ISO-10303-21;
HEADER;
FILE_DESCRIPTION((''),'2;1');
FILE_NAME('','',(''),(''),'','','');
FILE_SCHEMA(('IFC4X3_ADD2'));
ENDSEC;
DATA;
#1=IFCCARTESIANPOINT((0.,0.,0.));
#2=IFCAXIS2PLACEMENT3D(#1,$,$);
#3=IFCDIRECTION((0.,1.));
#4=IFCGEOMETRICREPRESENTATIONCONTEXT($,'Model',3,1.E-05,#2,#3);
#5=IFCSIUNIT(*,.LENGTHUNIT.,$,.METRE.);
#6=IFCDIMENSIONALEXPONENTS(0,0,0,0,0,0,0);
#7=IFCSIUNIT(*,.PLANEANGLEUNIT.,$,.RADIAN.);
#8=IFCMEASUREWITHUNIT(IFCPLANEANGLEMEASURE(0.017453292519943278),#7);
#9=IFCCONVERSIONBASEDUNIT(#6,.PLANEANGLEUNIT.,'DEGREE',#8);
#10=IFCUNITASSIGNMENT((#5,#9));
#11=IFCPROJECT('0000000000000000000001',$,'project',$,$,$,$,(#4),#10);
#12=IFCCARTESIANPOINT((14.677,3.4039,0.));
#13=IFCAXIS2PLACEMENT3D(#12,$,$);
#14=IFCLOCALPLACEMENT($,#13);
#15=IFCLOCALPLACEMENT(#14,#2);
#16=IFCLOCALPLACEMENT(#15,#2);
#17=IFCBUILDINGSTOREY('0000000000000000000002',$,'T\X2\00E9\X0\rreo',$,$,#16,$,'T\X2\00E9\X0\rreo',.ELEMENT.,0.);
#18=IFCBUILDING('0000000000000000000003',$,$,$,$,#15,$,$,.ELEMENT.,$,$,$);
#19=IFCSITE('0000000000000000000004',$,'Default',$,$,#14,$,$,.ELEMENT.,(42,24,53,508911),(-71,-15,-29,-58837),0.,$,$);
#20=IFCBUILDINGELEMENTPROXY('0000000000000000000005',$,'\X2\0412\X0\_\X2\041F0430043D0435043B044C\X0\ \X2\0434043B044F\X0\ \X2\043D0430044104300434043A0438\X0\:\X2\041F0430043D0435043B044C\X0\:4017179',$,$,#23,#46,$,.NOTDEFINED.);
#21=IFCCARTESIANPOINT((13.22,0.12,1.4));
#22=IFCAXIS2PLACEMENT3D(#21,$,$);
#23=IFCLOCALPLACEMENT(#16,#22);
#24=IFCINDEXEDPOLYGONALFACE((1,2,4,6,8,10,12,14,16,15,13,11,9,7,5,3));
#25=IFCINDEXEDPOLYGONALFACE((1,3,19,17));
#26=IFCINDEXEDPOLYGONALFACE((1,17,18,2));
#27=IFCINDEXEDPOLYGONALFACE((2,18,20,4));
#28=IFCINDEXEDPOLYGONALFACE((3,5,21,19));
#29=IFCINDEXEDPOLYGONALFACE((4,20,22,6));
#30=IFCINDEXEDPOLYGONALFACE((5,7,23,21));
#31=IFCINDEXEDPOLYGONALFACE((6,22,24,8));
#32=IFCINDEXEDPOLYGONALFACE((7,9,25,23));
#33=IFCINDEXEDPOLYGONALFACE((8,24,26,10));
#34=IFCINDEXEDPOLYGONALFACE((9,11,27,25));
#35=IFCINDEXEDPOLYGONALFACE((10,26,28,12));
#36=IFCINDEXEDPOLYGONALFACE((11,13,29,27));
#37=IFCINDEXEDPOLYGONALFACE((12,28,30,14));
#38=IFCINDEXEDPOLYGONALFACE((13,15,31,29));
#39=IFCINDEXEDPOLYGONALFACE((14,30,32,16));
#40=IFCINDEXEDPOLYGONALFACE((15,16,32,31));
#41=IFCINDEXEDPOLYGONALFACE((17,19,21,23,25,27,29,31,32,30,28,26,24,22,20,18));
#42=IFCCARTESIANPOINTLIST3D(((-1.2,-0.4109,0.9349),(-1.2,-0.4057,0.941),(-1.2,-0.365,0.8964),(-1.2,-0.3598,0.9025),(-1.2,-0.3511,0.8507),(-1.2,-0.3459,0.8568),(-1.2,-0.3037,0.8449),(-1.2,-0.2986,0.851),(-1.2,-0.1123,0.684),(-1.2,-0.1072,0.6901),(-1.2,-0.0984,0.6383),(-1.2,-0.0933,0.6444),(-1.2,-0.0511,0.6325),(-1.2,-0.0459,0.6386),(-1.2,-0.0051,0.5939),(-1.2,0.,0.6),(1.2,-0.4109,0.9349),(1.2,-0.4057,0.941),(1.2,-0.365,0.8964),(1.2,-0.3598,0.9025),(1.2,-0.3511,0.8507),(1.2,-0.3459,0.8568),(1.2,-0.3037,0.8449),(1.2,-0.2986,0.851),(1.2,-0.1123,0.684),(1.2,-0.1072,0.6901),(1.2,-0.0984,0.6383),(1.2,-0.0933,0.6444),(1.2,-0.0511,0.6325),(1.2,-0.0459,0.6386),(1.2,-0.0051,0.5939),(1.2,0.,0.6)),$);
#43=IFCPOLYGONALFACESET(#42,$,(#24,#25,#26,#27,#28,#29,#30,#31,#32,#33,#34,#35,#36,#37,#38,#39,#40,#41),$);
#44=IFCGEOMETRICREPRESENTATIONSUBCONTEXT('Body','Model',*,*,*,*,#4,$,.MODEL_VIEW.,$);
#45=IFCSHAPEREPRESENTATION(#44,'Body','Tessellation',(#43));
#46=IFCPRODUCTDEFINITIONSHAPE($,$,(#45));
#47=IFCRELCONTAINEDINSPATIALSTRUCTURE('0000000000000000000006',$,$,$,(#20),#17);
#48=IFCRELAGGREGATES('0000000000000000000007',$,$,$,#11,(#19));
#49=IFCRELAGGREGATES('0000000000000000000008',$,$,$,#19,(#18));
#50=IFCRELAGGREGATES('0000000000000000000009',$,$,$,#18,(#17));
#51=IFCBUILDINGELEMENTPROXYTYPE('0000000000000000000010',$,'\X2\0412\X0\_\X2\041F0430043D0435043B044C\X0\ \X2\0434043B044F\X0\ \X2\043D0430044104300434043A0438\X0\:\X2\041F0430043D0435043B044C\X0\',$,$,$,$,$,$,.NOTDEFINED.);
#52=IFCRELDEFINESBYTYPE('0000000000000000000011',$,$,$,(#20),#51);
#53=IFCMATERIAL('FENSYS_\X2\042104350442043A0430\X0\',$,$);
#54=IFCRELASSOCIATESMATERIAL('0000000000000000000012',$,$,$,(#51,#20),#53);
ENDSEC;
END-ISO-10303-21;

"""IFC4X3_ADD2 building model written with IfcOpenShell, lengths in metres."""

from ifc_helpers import new_model, entity, si_unit, converted_unit, direction, frame, origin, place, context, subcontext, project, spatial, polyline, outline, extrude, source, transform, mapped, material, type_object, type_shapes, element, save


model = new_model("IFC4X3_ADD2")

# Units and contexts
model_context = context("Model", 3, precision=1e-05, world=origin(), true_north=direction((0.0, 1.0)))
body_context = subcontext(model_context, "Body", "Model", "MODEL_VIEW")
ifc_project = project(units=[si_unit("LENGTHUNIT", "METRE"), converted_unit("PLANEANGLEUNIT", "DEGREE", entity("IfcPlaneAngleMeasure", 0.017453292519943278), si_unit("PLANEANGLEUNIT", "RADIAN"), dimensions=[0, 0, 0, 0, 0, 0, 0])], contexts=[model_context])

# Site, building, storey
site_placement = place(None, frame((14.677, 3.4039, 0.0)))
site = spatial("IfcSite", under=ifc_project, at=site_placement, Name="Default", CompositionType="ELEMENT", RefLatitude=(42, 24, 53, 508911), RefLongitude=(-71, -15, -29, -58837), RefElevation=0.0)
building_placement = place(site_placement, origin())
building = spatial("IfcBuilding", under=site, at=building_placement, CompositionType="ELEMENT")
storey_placement = place(building_placement, origin())
storey = spatial("IfcBuildingStorey", under=building, at=storey_placement, Name="Térreo", LongName="Térreo", CompositionType="ELEMENT", Elevation=0.0)

# Building element proxy
ifc_material_1 = material(Name="FENSYS_Сетка")
building_element_proxy_type_1 = type_object("IfcBuildingElementProxyType", Name="В_Панель для насадки:Панель", PredefinedType="NOTDEFINED", material=ifc_material_1)
shared_shape_1 = source(origin(), body_context, "Body", "SweptSolid", [
    extrude(outline(polyline([(0.205, -0.0105), (0.265, -0.0105), (0.265, -0.0025), (0.205, -0.0025), (0.165, 0.0235), (0.125, -0.0025), (-0.125, -0.0025), (-0.165, 0.0235), (-0.205, -0.0025), (-0.265, -0.0025), (-0.265, -0.0105), (-0.205, -0.0105), (-0.165, 0.0155), (-0.125, -0.0105), (0.125, -0.0105), (0.165, 0.0155), (0.205, -0.0105)])), frame((-1.2, -0.2096, 0.7625), z_axis=(1.0, 0.0, 0.0), x_axis=(0.0, -0.765483, 0.643456)), (0.0, 0.0, 1.0), 2.4),
])
type_shapes(building_element_proxy_type_1, [shared_shape_1])
proxy_1_placement = place(storey_placement, frame((13.22, 0.12, 1.4)))
element("IfcBuildingElementProxy", 1, at=proxy_1_placement, inside=storey, type_object=building_element_proxy_type_1, material=ifc_material_1, Name="В_Панель для насадки:Панель:4017179", PredefinedType="NOTDEFINED", context=body_context, shape_type="MappedRepresentation", body=[
    mapped(shared_shape_1, transform((0.0, 0.0, 0.0), scale=1.0)),
])

save(model, "model.ifc")
